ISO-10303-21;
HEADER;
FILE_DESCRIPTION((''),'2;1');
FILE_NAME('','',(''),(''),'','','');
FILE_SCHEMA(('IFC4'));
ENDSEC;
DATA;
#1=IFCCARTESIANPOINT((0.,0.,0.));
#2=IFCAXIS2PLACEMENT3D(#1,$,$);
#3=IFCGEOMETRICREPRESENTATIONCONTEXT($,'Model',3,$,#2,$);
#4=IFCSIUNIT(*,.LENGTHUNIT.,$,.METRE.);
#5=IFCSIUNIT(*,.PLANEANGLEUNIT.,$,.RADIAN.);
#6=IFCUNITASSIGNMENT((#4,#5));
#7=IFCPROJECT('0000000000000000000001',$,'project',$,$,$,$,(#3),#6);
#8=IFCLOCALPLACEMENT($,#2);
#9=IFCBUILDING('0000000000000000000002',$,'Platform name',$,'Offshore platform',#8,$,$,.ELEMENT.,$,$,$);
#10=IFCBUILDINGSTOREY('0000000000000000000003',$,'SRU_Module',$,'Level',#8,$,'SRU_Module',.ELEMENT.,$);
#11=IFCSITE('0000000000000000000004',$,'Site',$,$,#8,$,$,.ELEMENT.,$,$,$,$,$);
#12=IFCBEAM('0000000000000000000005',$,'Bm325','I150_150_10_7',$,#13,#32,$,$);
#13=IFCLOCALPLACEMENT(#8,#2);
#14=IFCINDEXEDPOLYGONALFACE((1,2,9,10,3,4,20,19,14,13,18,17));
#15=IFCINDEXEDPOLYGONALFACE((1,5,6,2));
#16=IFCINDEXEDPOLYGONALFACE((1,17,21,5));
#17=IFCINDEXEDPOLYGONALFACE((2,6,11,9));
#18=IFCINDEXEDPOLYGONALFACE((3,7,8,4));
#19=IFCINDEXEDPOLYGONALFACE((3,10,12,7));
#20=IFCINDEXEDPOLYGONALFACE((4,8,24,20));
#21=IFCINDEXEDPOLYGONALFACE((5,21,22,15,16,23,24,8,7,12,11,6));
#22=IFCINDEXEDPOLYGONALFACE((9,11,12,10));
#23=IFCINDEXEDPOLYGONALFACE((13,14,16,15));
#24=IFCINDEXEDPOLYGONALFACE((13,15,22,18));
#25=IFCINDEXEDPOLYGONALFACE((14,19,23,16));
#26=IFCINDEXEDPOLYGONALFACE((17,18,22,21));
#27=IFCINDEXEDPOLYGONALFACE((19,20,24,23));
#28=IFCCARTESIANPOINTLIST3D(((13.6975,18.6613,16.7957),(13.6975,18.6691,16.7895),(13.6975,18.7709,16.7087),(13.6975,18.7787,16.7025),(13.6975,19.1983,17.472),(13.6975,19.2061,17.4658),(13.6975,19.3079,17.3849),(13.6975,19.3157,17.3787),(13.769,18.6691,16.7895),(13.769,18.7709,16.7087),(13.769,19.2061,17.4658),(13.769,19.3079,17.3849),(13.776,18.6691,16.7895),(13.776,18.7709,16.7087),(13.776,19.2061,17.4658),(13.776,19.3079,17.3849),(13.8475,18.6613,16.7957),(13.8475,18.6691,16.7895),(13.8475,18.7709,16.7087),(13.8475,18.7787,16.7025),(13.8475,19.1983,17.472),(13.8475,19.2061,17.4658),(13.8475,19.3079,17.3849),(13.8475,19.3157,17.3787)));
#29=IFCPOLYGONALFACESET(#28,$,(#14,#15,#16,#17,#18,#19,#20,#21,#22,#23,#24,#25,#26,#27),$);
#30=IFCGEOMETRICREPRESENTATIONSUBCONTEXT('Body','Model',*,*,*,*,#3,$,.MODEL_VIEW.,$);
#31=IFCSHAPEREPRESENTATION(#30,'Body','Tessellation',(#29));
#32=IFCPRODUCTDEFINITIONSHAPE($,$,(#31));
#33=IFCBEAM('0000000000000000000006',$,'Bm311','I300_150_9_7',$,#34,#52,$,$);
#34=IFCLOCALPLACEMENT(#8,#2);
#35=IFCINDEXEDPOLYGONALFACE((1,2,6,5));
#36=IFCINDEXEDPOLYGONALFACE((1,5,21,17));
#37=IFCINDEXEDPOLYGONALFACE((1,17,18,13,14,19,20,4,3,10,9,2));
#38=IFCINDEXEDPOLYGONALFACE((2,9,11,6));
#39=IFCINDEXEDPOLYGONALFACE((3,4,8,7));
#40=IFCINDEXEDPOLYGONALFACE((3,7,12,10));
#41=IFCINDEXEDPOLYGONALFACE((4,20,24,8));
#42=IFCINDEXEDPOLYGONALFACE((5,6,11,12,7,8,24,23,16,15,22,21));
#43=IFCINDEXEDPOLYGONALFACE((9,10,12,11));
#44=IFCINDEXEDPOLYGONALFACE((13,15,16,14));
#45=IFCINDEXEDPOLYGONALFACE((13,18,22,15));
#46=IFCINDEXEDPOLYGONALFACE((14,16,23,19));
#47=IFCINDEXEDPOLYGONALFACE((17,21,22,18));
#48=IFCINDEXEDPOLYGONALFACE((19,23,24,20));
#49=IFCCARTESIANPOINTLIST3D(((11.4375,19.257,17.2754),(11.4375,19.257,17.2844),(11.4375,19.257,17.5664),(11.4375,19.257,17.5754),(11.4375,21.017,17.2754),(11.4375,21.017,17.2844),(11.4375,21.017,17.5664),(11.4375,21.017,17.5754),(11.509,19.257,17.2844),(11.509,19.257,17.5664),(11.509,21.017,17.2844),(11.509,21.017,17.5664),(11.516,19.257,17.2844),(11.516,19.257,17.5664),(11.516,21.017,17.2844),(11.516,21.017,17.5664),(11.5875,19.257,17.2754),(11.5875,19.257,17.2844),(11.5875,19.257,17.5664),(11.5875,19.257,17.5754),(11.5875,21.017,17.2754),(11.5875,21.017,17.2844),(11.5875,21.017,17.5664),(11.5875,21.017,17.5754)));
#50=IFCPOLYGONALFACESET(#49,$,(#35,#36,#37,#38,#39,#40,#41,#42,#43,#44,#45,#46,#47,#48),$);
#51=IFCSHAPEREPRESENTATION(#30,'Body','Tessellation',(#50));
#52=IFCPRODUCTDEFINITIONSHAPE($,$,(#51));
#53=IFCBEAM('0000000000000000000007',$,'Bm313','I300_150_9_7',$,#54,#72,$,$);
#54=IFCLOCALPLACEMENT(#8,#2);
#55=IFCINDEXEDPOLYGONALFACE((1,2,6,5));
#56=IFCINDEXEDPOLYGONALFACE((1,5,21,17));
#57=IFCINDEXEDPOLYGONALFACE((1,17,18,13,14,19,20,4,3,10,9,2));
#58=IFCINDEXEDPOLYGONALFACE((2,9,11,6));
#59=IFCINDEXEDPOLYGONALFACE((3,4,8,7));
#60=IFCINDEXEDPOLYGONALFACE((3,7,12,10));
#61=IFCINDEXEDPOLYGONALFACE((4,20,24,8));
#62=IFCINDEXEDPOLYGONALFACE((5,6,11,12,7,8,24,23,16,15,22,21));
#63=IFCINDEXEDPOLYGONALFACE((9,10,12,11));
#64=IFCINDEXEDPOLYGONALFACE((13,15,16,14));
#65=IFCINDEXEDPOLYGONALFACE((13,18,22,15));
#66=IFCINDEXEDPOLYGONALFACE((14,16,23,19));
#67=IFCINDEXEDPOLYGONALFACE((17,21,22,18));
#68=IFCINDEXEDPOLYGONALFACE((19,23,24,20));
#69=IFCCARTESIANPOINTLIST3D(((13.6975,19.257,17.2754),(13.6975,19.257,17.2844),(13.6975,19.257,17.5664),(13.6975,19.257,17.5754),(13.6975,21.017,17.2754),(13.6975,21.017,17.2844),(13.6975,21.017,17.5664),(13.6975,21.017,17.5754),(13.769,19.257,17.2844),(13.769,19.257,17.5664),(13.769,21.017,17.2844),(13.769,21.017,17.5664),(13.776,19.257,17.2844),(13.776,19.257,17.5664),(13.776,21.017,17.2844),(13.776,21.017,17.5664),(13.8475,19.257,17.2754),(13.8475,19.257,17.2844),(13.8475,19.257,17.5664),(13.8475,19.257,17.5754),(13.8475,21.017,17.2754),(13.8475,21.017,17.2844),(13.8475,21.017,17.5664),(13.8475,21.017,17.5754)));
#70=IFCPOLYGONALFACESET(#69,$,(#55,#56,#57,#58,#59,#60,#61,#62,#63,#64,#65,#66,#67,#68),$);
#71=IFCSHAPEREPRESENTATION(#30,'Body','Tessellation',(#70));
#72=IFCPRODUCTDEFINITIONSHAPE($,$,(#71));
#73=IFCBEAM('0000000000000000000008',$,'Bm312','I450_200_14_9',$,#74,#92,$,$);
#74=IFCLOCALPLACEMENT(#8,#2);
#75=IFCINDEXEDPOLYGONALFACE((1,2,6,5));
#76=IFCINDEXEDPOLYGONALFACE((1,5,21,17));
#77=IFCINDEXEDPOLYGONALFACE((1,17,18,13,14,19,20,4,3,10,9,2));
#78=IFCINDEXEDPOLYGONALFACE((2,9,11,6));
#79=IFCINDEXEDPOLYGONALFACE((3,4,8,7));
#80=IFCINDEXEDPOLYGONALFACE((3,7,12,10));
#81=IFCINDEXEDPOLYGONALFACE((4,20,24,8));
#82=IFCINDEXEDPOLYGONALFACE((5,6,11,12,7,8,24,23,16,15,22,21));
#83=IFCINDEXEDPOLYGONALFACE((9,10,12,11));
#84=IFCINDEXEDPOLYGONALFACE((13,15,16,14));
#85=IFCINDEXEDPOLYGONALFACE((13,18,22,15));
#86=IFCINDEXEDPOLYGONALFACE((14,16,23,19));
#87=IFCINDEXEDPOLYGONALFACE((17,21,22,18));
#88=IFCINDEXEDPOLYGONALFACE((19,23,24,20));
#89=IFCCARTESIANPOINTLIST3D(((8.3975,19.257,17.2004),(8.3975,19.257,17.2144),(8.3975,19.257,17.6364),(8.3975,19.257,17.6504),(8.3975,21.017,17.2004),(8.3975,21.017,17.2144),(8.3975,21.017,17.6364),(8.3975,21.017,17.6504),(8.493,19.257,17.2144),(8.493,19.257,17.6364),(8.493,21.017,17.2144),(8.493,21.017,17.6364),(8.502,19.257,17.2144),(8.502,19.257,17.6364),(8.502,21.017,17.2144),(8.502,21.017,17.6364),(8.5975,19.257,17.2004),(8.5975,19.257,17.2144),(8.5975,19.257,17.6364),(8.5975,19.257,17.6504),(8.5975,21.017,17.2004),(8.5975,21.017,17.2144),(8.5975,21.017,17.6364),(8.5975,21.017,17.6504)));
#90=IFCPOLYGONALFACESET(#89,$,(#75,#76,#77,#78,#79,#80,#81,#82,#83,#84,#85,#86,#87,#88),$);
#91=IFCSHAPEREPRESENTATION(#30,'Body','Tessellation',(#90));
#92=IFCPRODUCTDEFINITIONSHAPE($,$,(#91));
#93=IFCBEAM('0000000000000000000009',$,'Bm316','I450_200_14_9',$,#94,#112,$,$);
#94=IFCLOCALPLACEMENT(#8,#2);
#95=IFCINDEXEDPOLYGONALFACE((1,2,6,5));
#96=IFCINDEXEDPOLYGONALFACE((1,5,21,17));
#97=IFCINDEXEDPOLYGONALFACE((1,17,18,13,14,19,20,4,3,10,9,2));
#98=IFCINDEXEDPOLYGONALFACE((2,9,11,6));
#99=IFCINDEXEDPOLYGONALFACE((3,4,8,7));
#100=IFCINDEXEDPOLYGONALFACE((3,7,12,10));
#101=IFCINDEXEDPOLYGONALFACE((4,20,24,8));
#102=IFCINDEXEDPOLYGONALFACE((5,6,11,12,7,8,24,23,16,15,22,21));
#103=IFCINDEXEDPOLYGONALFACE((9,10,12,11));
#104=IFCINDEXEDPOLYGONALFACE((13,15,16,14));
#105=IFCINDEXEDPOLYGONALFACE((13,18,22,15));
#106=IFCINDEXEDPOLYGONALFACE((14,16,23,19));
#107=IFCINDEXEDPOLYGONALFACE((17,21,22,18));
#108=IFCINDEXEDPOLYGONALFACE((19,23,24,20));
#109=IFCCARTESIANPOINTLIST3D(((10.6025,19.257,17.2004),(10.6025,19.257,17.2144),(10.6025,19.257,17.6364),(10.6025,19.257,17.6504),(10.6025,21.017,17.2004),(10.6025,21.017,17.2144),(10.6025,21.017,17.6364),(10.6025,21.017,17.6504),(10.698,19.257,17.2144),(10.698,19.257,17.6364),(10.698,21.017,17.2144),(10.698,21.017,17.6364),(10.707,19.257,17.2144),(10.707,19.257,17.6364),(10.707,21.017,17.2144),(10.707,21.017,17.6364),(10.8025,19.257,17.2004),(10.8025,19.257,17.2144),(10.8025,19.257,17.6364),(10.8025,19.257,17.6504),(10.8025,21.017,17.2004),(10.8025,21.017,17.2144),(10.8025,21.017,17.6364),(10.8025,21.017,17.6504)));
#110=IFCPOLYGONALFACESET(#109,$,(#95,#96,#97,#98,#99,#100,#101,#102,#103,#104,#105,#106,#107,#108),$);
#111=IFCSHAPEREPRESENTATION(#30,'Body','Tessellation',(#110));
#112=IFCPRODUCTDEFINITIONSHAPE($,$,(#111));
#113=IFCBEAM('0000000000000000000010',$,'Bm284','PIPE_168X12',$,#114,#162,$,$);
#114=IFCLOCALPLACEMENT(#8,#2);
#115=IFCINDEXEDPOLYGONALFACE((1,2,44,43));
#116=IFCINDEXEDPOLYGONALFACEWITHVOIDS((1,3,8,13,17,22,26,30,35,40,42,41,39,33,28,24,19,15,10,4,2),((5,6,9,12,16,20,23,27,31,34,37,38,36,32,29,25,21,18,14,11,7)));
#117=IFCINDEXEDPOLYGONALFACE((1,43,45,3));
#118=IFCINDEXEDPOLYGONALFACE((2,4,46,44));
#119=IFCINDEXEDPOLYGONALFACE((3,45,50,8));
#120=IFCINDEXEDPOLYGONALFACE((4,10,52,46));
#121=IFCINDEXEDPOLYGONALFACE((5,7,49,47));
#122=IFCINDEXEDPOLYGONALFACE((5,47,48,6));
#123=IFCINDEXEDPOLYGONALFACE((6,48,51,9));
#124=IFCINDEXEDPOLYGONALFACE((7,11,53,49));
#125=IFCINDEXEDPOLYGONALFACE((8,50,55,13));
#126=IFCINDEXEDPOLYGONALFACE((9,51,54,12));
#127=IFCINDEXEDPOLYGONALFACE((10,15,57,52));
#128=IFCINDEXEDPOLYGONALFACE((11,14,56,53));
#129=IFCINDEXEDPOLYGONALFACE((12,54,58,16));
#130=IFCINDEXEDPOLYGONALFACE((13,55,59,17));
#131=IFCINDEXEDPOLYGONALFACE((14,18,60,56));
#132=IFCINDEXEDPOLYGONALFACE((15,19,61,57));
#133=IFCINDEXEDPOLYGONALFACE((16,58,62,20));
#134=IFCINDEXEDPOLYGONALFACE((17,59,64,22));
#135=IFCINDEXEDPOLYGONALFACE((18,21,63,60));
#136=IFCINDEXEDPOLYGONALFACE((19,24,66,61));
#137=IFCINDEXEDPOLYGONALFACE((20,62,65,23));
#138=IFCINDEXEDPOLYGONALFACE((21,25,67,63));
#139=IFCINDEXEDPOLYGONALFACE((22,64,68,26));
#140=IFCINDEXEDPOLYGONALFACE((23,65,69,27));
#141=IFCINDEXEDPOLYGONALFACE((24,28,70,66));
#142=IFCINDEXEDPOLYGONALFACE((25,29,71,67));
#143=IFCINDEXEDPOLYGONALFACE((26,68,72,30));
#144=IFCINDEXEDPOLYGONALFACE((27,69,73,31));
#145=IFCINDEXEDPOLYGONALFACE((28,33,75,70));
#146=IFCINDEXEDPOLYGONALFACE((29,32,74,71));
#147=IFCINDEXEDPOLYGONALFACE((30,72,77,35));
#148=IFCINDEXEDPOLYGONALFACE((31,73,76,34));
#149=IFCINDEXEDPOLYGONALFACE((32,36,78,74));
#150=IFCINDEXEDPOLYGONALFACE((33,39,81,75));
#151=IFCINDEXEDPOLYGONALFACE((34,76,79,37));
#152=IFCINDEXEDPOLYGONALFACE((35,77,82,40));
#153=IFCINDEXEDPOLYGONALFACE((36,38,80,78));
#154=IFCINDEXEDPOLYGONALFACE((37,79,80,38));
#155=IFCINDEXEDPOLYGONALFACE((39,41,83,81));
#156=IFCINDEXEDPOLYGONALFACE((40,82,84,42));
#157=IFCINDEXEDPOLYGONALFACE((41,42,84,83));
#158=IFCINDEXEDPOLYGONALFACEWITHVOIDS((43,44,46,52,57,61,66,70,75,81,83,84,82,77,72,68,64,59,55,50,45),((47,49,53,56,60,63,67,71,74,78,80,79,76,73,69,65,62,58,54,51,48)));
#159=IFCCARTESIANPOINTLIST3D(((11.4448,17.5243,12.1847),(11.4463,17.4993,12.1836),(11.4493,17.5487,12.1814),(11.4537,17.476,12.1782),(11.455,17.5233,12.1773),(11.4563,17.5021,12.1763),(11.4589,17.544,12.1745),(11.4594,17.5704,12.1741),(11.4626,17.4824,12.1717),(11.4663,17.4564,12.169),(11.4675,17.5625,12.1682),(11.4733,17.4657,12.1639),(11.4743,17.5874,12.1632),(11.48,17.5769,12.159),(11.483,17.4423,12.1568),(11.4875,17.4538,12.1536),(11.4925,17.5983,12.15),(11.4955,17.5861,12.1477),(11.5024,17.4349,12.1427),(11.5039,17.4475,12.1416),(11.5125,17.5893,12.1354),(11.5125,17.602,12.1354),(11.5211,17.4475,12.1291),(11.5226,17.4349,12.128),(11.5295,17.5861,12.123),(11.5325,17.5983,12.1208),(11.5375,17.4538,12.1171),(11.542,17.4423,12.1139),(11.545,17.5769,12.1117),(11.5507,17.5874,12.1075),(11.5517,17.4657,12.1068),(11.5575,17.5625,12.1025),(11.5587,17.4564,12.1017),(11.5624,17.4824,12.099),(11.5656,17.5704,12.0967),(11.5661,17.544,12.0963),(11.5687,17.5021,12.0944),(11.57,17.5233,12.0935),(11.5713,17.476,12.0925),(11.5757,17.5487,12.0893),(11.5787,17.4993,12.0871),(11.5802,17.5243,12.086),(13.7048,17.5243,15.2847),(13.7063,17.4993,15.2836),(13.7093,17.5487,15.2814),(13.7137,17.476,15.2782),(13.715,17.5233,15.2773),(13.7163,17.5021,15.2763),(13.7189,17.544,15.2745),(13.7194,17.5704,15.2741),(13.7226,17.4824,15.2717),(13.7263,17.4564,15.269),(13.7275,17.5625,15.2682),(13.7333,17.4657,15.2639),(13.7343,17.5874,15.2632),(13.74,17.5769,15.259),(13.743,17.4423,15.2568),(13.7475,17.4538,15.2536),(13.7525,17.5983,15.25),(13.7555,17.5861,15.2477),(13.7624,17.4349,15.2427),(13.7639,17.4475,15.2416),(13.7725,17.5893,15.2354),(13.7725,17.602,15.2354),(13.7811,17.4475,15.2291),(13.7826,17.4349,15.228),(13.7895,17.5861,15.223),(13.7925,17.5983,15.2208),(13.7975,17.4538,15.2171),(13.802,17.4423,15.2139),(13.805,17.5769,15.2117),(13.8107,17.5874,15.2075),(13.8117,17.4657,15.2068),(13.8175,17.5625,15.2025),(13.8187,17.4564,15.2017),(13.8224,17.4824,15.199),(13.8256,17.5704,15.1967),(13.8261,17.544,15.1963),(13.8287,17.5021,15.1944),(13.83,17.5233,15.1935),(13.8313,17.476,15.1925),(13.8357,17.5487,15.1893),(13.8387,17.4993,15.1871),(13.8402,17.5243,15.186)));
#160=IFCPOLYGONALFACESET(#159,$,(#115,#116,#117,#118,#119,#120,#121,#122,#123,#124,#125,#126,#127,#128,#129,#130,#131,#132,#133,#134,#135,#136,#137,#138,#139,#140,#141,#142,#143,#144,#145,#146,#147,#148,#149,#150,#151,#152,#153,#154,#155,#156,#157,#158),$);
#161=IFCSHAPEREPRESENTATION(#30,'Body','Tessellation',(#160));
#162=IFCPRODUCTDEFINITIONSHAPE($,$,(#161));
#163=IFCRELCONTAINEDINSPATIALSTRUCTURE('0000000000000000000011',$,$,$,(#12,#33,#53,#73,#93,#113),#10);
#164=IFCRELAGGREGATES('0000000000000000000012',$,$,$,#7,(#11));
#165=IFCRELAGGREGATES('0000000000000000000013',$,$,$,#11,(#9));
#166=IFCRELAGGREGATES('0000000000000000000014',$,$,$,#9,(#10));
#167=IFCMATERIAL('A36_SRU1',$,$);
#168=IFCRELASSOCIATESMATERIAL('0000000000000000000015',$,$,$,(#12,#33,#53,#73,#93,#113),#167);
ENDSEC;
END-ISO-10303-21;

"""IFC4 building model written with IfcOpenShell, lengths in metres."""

from ifc_helpers import new_model, si_unit, frame, origin, origin_2d, place, context, subcontext, project, spatial, hollow_circle, i_section, extrude, source, transform, mapped, material, element, save


model = new_model("IFC4")

# Units and contexts
model_context = context("Model", 3, world=origin())
body_context = subcontext(model_context, "Body", "Model", "MODEL_VIEW")
ifc_project = project(units=[si_unit("LENGTHUNIT", "METRE"), si_unit("PLANEANGLEUNIT", "RADIAN")], contexts=[model_context])

# Site, building, storey
placement_1 = place(None, origin())
site = spatial("IfcSite", under=ifc_project, at=placement_1, Name="Site", CompositionType="ELEMENT")
building = spatial("IfcBuilding", under=site, at=placement_1, Name="Platform name", ObjectType="Offshore platform", CompositionType="ELEMENT")
storey = spatial("IfcBuildingStorey", under=building, at=placement_1, Name="SRU_Module", ObjectType="Level", LongName="SRU_Module", CompositionType="ELEMENT")

# Beams
ifc_material_1 = material(Name="A36_SRU1")
shared_shape_1 = source(origin(), body_context, "Body", "SweptSolid", [
    extrude(i_section(OverallWidth=0.15, OverallDepth=0.15, WebThickness=0.007, FlangeThickness=0.01, FilletRadius=0.0, at=origin_2d()), frame((0.0, 0.0, 0.0), z_axis=(0.0, 0.621856, 0.783131), x_axis=(-1.0, 0.0, 0.0)), (0.0, 0.0, 1.0), 0.8635),
])
placement_2 = place(None, origin())
placement_3 = place(placement_2, origin())
placement_4 = place(placement_3, origin())
beam_1_placement = place(placement_4, frame((13.7725, 18.72, 16.7491)))
element("IfcBeam", 1, at=beam_1_placement, inside=storey, material=ifc_material_1, Name="Bm325", Description="I150_150_10_7", context=body_context, shape_type="MappedRepresentation", body=[
    mapped(shared_shape_1, transform((0.0, 0.0, 0.0), scale=1.0)),
])
shared_shape_2 = source(origin(), body_context, "Body", "SweptSolid", [
    extrude(i_section(OverallWidth=0.15, OverallDepth=0.3, WebThickness=0.007, FlangeThickness=0.009, FilletRadius=0.0, at=origin_2d()), frame((0.0, 0.0, 0.0), z_axis=(0.0, 1.0, 0.0), x_axis=(-1.0, 0.0, 0.0)), (0.0, 0.0, 1.0), 1.76),
])
placement_5 = place(None, origin())
placement_6 = place(placement_5, origin())
placement_7 = place(placement_6, origin())
beam_2_placement = place(placement_7, frame((11.5125, 19.257, 17.4254)))
element("IfcBeam", 2, at=beam_2_placement, inside=storey, material=ifc_material_1, Name="Bm311", Description="I300_150_9_7", context=body_context, shape_type="MappedRepresentation", body=[
    mapped(shared_shape_2, transform((0.0, 0.0, 0.0), scale=1.0)),
])
shared_shape_3 = source(origin(), body_context, "Body", "SweptSolid", [
    extrude(i_section(OverallWidth=0.15, OverallDepth=0.3, WebThickness=0.007, FlangeThickness=0.009, FilletRadius=0.0, at=origin_2d()), frame((0.0, 0.0, 0.0), z_axis=(0.0, 1.0, 0.0), x_axis=(-1.0, 0.0, 0.0)), (0.0, 0.0, 1.0), 1.76),
])
placement_8 = place(None, origin())
placement_9 = place(placement_8, origin())
placement_10 = place(placement_9, origin())
beam_3_placement = place(placement_10, frame((13.7725, 19.257, 17.4254)))
element("IfcBeam", 3, at=beam_3_placement, inside=storey, material=ifc_material_1, Name="Bm313", Description="I300_150_9_7", context=body_context, shape_type="MappedRepresentation", body=[
    mapped(shared_shape_3, transform((0.0, 0.0, 0.0), scale=1.0)),
])
shared_shape_4 = source(origin(), body_context, "Body", "SweptSolid", [
    extrude(i_section(OverallWidth=0.2, OverallDepth=0.45, WebThickness=0.009, FlangeThickness=0.014, FilletRadius=0.0, at=origin_2d()), frame((0.0, 0.0, 0.0), z_axis=(0.0, 1.0, 0.0), x_axis=(-1.0, 0.0, 0.0)), (0.0, 0.0, 1.0), 1.76),
])
placement_11 = place(None, origin())
placement_12 = place(placement_11, origin())
placement_13 = place(placement_12, origin())
beam_4_placement = place(placement_13, frame((8.4975, 19.257, 17.4254)))
element("IfcBeam", 4, at=beam_4_placement, inside=storey, material=ifc_material_1, Name="Bm312", Description="I450_200_14_9", context=body_context, shape_type="MappedRepresentation", body=[
    mapped(shared_shape_4, transform((0.0, 0.0, 0.0), scale=1.0)),
])
shared_shape_5 = source(origin(), body_context, "Body", "SweptSolid", [
    extrude(i_section(OverallWidth=0.2, OverallDepth=0.45, WebThickness=0.009, FlangeThickness=0.014, FilletRadius=0.0, at=origin_2d()), frame((0.0, 0.0, 0.0), z_axis=(0.0, 1.0, 0.0), x_axis=(-1.0, 0.0, 0.0)), (0.0, 0.0, 1.0), 1.76),
])
placement_14 = place(None, origin())
placement_15 = place(placement_14, origin())
placement_16 = place(placement_15, origin())
beam_5_placement = place(placement_16, frame((10.7025, 19.257, 17.4254)))
element("IfcBeam", 5, at=beam_5_placement, inside=storey, material=ifc_material_1, Name="Bm316", Description="I450_200_14_9", context=body_context, shape_type="MappedRepresentation", body=[
    mapped(shared_shape_5, transform((0.0, 0.0, 0.0), scale=1.0)),
])
shared_shape_6 = source(origin(), body_context, "Body", "SweptSolid", [
    extrude(hollow_circle(Radius=0.084, WallThickness=0.0127, at=origin_2d()), frame((0.0, 0.0, 0.0), z_axis=(0.589101, 0.0, 0.808059), x_axis=(0.0, 1.0, 0.0)), (0.0, 0.0, 1.0), 3.8364),
])
placement_17 = place(None, origin())
placement_18 = place(placement_17, origin())
placement_19 = place(placement_18, origin())
beam_6_placement = place(placement_19, frame((11.5125, 17.518, 12.1354)))
element("IfcBeam", 6, at=beam_6_placement, inside=storey, material=ifc_material_1, Name="Bm284", Description="PIPE_168X12", context=body_context, shape_type="MappedRepresentation", body=[
    mapped(shared_shape_6, transform((0.0, 0.0, 0.0), scale=1.0)),
])

save(model, "model.ifc")
